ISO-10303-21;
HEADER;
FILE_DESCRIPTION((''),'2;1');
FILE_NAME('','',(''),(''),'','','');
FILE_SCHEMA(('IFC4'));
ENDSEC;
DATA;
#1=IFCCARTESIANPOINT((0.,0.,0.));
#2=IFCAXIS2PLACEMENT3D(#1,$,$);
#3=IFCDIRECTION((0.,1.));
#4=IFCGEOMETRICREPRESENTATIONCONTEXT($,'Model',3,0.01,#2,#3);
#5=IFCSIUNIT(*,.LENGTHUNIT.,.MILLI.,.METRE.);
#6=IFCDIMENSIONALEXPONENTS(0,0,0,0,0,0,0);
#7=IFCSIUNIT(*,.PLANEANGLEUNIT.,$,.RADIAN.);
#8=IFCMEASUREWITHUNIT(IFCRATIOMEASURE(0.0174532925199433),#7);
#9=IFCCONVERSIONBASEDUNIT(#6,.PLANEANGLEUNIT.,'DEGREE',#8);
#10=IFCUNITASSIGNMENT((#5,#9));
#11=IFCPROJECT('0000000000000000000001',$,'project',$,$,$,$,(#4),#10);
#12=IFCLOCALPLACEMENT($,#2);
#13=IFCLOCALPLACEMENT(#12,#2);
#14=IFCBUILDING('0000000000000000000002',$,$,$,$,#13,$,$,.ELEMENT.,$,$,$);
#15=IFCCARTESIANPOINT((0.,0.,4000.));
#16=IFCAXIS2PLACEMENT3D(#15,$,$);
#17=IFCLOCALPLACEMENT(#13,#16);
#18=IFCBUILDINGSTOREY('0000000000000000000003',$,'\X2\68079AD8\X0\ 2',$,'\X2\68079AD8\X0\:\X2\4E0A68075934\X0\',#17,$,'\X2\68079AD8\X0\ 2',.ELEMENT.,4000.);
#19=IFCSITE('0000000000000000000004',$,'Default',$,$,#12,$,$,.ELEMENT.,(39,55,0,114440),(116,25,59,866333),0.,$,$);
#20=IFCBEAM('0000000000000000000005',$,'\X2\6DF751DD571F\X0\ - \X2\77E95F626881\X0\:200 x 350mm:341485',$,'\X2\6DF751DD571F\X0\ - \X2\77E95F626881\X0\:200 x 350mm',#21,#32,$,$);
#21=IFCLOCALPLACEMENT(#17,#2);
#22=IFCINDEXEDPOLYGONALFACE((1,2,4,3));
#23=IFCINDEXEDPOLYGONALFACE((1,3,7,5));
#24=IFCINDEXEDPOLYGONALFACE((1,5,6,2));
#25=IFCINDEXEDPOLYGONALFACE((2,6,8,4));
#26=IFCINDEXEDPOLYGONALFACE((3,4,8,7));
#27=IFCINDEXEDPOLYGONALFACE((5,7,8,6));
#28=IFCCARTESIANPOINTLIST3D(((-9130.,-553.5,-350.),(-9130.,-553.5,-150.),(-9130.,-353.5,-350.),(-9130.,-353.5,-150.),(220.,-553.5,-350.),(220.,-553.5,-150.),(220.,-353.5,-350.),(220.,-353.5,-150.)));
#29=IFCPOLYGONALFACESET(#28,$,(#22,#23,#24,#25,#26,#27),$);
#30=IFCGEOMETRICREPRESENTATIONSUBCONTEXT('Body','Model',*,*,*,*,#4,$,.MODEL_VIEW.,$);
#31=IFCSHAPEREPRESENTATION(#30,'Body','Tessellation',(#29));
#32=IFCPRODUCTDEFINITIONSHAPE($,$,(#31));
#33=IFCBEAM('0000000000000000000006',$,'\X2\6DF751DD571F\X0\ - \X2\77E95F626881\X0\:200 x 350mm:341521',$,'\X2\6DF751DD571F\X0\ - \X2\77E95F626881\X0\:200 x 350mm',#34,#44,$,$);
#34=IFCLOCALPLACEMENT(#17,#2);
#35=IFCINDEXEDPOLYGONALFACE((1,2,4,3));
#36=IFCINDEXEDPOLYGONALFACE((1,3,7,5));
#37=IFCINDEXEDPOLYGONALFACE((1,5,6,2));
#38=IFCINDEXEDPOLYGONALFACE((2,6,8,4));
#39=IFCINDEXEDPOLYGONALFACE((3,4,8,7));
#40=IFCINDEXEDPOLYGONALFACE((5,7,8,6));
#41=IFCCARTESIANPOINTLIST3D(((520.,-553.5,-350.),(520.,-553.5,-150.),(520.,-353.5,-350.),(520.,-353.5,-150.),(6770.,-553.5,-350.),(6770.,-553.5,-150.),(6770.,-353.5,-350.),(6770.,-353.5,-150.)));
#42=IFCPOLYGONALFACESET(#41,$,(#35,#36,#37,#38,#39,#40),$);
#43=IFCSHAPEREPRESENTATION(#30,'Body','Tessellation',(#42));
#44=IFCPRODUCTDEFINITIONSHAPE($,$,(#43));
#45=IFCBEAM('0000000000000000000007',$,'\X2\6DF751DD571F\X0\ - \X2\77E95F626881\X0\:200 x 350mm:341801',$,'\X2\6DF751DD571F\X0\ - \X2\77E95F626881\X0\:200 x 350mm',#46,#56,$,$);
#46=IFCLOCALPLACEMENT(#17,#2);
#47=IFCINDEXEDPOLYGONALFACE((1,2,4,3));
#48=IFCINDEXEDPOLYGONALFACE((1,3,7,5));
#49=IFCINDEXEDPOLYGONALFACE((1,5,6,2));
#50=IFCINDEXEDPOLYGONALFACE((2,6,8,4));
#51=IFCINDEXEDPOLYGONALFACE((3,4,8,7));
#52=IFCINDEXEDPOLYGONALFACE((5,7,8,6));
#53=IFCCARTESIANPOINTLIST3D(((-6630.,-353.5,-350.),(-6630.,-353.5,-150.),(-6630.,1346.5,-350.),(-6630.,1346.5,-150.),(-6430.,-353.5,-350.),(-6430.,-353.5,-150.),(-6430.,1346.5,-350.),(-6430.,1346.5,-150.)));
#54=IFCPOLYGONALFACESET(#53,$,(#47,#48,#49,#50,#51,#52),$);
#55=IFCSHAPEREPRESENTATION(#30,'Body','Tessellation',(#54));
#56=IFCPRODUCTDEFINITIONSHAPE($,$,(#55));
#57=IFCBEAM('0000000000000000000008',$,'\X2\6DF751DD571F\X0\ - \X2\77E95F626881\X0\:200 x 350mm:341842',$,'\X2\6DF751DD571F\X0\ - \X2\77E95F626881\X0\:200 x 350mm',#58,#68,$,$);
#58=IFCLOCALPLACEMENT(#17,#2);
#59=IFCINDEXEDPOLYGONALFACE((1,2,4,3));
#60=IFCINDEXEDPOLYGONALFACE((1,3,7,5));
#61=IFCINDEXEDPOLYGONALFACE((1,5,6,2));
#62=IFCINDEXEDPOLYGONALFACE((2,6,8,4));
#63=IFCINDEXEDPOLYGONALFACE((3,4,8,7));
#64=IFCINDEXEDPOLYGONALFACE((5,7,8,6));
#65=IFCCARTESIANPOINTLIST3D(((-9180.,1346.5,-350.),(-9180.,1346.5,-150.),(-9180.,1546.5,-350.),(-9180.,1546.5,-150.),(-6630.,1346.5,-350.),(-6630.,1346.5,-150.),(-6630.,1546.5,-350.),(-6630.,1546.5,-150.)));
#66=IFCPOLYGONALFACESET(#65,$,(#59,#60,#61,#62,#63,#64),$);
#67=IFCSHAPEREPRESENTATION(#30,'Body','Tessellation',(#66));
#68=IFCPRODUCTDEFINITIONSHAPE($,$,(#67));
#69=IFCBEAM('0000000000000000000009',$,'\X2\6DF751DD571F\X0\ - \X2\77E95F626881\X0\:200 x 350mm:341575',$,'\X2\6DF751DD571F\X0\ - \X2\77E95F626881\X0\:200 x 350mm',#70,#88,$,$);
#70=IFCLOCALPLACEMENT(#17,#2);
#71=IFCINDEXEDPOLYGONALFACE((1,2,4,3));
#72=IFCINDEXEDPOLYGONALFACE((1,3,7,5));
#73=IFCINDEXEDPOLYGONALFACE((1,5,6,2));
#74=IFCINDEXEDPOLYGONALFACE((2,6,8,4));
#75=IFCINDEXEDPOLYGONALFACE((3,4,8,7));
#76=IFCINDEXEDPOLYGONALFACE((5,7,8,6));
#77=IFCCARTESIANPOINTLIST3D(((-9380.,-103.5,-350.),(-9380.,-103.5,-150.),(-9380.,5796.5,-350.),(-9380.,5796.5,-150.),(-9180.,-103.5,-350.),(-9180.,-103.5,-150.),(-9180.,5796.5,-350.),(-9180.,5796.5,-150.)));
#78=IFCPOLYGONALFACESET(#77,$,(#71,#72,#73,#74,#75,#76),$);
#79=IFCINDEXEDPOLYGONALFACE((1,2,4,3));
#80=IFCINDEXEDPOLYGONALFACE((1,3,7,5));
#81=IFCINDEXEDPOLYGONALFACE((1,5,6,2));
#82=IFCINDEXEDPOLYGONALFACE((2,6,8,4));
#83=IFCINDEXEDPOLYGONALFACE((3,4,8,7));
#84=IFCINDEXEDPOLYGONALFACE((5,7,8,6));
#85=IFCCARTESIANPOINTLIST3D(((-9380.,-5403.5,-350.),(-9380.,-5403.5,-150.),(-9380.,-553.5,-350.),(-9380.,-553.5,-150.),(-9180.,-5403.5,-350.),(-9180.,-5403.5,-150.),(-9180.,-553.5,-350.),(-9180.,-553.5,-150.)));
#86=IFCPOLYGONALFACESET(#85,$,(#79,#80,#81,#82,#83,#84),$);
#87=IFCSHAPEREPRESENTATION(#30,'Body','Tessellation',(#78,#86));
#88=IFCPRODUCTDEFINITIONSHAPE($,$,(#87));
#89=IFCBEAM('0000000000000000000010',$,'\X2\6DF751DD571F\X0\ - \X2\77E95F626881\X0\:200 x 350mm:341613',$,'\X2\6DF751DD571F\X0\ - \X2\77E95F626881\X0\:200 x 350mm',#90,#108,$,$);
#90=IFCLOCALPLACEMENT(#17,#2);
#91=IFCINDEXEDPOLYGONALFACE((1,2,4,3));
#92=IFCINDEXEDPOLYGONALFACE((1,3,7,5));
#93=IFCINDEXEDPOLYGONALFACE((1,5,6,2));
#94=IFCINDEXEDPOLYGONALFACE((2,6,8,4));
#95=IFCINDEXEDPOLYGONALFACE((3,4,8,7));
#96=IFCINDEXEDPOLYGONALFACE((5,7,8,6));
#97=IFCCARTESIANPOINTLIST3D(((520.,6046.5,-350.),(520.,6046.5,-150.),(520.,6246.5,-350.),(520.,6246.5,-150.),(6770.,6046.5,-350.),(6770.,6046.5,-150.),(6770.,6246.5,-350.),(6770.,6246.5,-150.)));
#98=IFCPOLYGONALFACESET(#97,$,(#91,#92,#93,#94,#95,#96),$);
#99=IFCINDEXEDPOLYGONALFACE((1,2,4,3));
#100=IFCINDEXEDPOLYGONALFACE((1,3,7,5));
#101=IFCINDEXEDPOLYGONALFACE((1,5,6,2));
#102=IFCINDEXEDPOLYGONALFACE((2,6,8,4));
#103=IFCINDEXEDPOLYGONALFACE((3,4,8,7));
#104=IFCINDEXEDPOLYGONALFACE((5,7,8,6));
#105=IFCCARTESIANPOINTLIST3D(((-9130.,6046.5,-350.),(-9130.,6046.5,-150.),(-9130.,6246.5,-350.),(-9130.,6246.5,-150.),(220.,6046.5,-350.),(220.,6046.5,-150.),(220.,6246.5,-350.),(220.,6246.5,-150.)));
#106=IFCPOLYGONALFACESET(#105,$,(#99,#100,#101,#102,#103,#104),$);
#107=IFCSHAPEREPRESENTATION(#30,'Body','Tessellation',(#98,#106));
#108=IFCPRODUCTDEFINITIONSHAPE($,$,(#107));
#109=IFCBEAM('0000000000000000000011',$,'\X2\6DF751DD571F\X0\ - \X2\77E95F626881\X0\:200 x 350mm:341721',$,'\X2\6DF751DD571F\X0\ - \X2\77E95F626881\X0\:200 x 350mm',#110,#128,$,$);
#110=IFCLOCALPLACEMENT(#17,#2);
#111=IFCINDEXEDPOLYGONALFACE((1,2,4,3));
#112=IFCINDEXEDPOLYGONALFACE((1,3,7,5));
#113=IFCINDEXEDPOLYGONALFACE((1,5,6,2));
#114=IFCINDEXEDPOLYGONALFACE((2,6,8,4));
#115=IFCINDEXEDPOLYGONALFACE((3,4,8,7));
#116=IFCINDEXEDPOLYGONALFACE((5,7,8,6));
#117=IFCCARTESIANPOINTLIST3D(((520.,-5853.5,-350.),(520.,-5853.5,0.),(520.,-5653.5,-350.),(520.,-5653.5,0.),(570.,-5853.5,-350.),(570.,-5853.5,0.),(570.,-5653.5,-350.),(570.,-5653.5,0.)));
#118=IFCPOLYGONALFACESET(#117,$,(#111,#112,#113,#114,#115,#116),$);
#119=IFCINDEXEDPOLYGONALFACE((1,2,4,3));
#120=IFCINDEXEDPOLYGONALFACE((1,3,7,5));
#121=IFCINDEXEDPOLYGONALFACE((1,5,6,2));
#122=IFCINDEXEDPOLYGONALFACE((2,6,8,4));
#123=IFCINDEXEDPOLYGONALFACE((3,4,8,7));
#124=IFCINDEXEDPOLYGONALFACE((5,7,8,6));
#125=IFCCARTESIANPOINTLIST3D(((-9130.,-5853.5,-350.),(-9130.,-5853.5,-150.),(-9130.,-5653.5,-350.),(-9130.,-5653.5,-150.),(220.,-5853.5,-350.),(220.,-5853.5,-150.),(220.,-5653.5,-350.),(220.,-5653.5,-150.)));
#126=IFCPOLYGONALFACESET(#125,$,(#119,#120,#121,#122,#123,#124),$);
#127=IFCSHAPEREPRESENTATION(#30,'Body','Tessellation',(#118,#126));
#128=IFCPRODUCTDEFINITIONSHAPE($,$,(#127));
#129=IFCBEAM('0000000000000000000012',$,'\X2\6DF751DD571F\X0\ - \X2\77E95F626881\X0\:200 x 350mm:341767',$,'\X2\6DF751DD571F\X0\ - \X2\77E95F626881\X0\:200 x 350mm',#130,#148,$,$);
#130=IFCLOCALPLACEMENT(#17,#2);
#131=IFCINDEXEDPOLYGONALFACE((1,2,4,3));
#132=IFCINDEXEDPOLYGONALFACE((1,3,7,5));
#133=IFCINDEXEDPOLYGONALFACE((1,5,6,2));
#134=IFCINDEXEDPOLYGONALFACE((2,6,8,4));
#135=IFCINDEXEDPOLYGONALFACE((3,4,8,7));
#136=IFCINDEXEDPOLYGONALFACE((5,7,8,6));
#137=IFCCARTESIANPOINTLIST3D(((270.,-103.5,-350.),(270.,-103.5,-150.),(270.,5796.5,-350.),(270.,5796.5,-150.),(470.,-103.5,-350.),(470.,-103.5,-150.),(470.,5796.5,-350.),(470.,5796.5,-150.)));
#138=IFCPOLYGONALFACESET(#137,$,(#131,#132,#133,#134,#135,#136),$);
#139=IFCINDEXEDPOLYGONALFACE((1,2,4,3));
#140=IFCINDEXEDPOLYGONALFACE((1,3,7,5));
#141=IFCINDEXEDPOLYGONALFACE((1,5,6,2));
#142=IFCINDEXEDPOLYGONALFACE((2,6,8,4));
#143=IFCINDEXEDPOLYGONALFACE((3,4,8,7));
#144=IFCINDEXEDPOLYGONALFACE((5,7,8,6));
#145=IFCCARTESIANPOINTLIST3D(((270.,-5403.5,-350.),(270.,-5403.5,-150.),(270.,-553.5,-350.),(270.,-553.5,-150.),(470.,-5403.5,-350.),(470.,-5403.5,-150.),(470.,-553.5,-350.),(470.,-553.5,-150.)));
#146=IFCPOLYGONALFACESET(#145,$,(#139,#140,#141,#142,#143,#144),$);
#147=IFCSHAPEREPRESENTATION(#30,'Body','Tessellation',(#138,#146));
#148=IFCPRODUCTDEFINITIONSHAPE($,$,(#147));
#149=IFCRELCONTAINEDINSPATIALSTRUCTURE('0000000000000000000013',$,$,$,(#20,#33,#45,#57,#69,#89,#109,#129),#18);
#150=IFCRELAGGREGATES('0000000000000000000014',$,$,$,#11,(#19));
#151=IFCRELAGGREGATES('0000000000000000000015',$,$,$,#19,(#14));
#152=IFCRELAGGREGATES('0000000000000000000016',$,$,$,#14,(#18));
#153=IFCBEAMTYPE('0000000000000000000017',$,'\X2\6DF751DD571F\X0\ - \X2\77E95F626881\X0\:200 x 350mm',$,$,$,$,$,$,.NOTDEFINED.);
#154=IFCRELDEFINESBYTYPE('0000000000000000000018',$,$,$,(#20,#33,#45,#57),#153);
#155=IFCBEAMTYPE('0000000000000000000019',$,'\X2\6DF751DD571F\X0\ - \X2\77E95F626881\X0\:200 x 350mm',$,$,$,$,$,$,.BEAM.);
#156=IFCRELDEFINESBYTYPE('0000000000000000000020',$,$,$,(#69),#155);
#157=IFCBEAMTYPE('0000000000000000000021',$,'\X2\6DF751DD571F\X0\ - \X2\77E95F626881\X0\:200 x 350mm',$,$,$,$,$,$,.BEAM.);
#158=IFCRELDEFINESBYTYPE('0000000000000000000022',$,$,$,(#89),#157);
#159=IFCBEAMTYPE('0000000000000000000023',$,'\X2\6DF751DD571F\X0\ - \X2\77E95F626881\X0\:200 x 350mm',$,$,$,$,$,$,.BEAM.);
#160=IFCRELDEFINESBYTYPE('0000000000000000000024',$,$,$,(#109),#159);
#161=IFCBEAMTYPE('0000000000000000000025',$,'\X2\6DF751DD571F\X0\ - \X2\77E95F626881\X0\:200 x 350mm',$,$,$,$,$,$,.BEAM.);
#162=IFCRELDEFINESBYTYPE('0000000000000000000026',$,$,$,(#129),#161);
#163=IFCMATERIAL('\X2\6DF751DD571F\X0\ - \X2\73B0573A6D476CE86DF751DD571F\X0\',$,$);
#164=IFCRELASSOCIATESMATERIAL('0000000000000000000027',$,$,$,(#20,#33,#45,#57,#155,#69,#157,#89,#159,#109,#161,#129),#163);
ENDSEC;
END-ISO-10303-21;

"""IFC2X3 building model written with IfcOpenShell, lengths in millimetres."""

from ifc_helpers import new_model, entity, si_unit, converted_unit, direction, frame, frame_2d, origin, place, context, subcontext, project, spatial, rectangle, extrude, source, transform, mapped, material, type_object, type_shapes, element, save


model = new_model("IFC2X3")

# Units and contexts
model_context = context("Model", 3, precision=0.01, world=origin(), true_north=direction((0.0, 1.0)))
body_context = subcontext(model_context, "Body", "Model", "MODEL_VIEW")
ifc_project = project(units=[si_unit("LENGTHUNIT", "METRE", prefix="MILLI"), converted_unit("PLANEANGLEUNIT", "DEGREE", entity("IfcRatioMeasure", 0.0174532925199433), si_unit("PLANEANGLEUNIT", "RADIAN"), dimensions=[0, 0, 0, 0, 0, 0, 0])], contexts=[model_context])

# Site, building, storey
site_placement = place(None, origin())
site = spatial("IfcSite", under=ifc_project, at=site_placement, Name="Default", CompositionType="ELEMENT", RefLatitude=(39, 55, 0, 114440), RefLongitude=(116, 25, 59, 866333), RefElevation=0.0)
building_placement = place(site_placement, origin())
building = spatial("IfcBuilding", under=site, at=building_placement, CompositionType="ELEMENT")
storey_placement = place(building_placement, frame((0.0, 0.0, 4000.0)))
storey = spatial("IfcBuildingStorey", under=building, at=storey_placement, Name="标高 2", ObjectType="标高:上标头", LongName="标高 2", CompositionType="ELEMENT", Elevation=4000.0)

# Beams
ifc_material_1 = material(Name="混凝土 - 现场浇注混凝土")
beam_type_1 = type_object("IfcBeamType", Name="混凝土 - 矩形梁:200 x 350mm", PredefinedType="NOTDEFINED")
beam_1_placement = place(storey_placement, frame((-9280.0, -453.5, 0.0)))
element("IfcBeam", 1, at=beam_1_placement, inside=storey, type_object=beam_type_1, material=ifc_material_1, Name="混凝土 - 矩形梁:200 x 350mm:341485", ObjectType="混凝土 - 矩形梁:200 x 350mm", context=body_context, shape_type="SweptSolid", body=[
    extrude(rectangle(XDim=200.0, YDim=200.0, at=frame_2d((0.0, 0.0), x_axis=(1.0, 0.0))), frame((150.0, 0.0, -250.0), z_axis=(1.0, 0.0, 0.0), x_axis=(0.0, 0.0, -1.0)), (0.0, 0.0, 1.0), 9350.0),
])
beam_2_placement = place(storey_placement, frame((370.0, -453.5, 0.0)))
element("IfcBeam", 2, at=beam_2_placement, inside=storey, type_object=beam_type_1, material=ifc_material_1, Name="混凝土 - 矩形梁:200 x 350mm:341521", ObjectType="混凝土 - 矩形梁:200 x 350mm", context=body_context, shape_type="SweptSolid", body=[
    extrude(rectangle(XDim=200.0, YDim=200.0, at=frame_2d((0.0, 0.0), x_axis=(1.0, 0.0))), frame((150.0, 0.0, -250.0), z_axis=(1.0, 0.0, 0.0), x_axis=(0.0, 0.0, -1.0)), (0.0, 0.0, 1.0), 6250.0),
])
beam_3_placement = place(storey_placement, frame((-6530.0, -453.5, 0.0), z_axis=(0.0, 0.0, 1.0), x_axis=(0.0, 1.0, 0.0)))
element("IfcBeam", 3, at=beam_3_placement, inside=storey, type_object=beam_type_1, material=ifc_material_1, Name="混凝土 - 矩形梁:200 x 350mm:341801", ObjectType="混凝土 - 矩形梁:200 x 350mm", context=body_context, shape_type="SweptSolid", body=[
    extrude(rectangle(XDim=200.0, YDim=200.0, at=frame_2d((0.0, 0.0), x_axis=(1.0, 0.0))), frame((100.0, 0.0, -250.0), z_axis=(1.0, 0.0, 0.0), x_axis=(0.0, 0.0, -1.0)), (0.0, 0.0, 1.0), 1700.0),
])
beam_4_placement = place(storey_placement, frame((-9280.0, 1446.5, 0.0)))
element("IfcBeam", 4, at=beam_4_placement, inside=storey, type_object=beam_type_1, material=ifc_material_1, Name="混凝土 - 矩形梁:200 x 350mm:341842", ObjectType="混凝土 - 矩形梁:200 x 350mm", context=body_context, shape_type="SweptSolid", body=[
    extrude(rectangle(XDim=200.0, YDim=200.0, at=frame_2d((0.0, 0.0), x_axis=(1.0, 0.0))), frame((100.0, 0.0, -250.0), z_axis=(1.0, 0.0, 0.0), x_axis=(0.0, 0.0, -1.0)), (0.0, 0.0, 1.0), 2550.0),
])
beam_type_2 = type_object("IfcBeamType", Name="混凝土 - 矩形梁:200 x 350mm", PredefinedType="BEAM", material=ifc_material_1)
shared_shape_1 = source(origin(), body_context, "Body", "SweptSolid", [
    extrude(rectangle(XDim=200.0, YDim=200.0, at=frame_2d((0.0, 0.0), x_axis=(0.0, 1.0))), frame((-9280.0, -103.5, 3750.0), z_axis=(0.0, 1.0, 0.0), x_axis=(-1.0, 0.0, 0.0)), (0.0, 0.0, 1.0), 5900.0),
    extrude(rectangle(XDim=200.0, YDim=200.0, at=frame_2d((0.0, 0.0), x_axis=(0.0, 1.0))), frame((-9280.0, -5403.5, 3750.0), z_axis=(0.0, 1.0, 0.0), x_axis=(-1.0, 0.0, 0.0)), (0.0, 0.0, 1.0), 4850.0),
])
type_shapes(beam_type_2, [shared_shape_1])
beam_5_placement = place(storey_placement, frame((0.0, 0.0, -4000.0)))
element("IfcBeam", 5, at=beam_5_placement, inside=storey, type_object=beam_type_2, material=ifc_material_1, Name="混凝土 - 矩形梁:200 x 350mm:341575", ObjectType="混凝土 - 矩形梁:200 x 350mm", context=body_context, shape_type="MappedRepresentation", body=[
    mapped(shared_shape_1, transform((0.0, 0.0, 0.0), scale=1.0)),
])
beam_type_3 = type_object("IfcBeamType", Name="混凝土 - 矩形梁:200 x 350mm", PredefinedType="BEAM", material=ifc_material_1)
shared_shape_2 = source(origin(), body_context, "Body", "SweptSolid", [
    extrude(rectangle(XDim=200.0, YDim=200.0, at=frame_2d((0.0, 0.0), x_axis=(1.0, 0.0))), frame((520.0, 6146.5, 3750.0), z_axis=(1.0, 0.0, 0.0), x_axis=(0.0, 0.0, -1.0)), (0.0, 0.0, 1.0), 6250.0),
    extrude(rectangle(XDim=200.0, YDim=200.0, at=frame_2d((0.0, 0.0), x_axis=(1.0, 0.0))), frame((-9130.0, 6146.5, 3750.0), z_axis=(1.0, 0.0, 0.0), x_axis=(0.0, 0.0, -1.0)), (0.0, 0.0, 1.0), 9350.0),
])
type_shapes(beam_type_3, [shared_shape_2])
beam_6_placement = place(storey_placement, frame((0.0, 0.0, -4000.0)))
element("IfcBeam", 6, at=beam_6_placement, inside=storey, type_object=beam_type_3, material=ifc_material_1, Name="混凝土 - 矩形梁:200 x 350mm:341613", ObjectType="混凝土 - 矩形梁:200 x 350mm", context=body_context, shape_type="MappedRepresentation", body=[
    mapped(shared_shape_2, transform((0.0, 0.0, 0.0), scale=1.0)),
])
beam_type_4 = type_object("IfcBeamType", Name="混凝土 - 矩形梁:200 x 350mm", PredefinedType="BEAM", material=ifc_material_1)
shared_shape_3 = source(origin(), body_context, "Body", "SweptSolid", [
    extrude(rectangle(XDim=350.0, YDim=200.0, at=frame_2d((0.0, 0.0), x_axis=(1.0, 0.0))), frame((520.0, -5753.5, 3825.0), z_axis=(1.0, 0.0, 0.0), x_axis=(0.0, 0.0, -1.0)), (0.0, 0.0, 1.0), 50.0),
    extrude(rectangle(XDim=200.0, YDim=200.0, at=frame_2d((0.0, 0.0), x_axis=(1.0, 0.0))), frame((-9130.0, -5753.5, 3750.0), z_axis=(1.0, 0.0, 0.0), x_axis=(0.0, 0.0, -1.0)), (0.0, 0.0, 1.0), 9350.0),
])
type_shapes(beam_type_4, [shared_shape_3])
beam_7_placement = place(storey_placement, frame((0.0, 0.0, -4000.0)))
element("IfcBeam", 7, at=beam_7_placement, inside=storey, type_object=beam_type_4, material=ifc_material_1, Name="混凝土 - 矩形梁:200 x 350mm:341721", ObjectType="混凝土 - 矩形梁:200 x 350mm", context=body_context, shape_type="MappedRepresentation", body=[
    mapped(shared_shape_3, transform((0.0, 0.0, 0.0), scale=1.0)),
])
beam_type_5 = type_object("IfcBeamType", Name="混凝土 - 矩形梁:200 x 350mm", PredefinedType="BEAM", material=ifc_material_1)
shared_shape_4 = source(origin(), body_context, "Body", "SweptSolid", [
    extrude(rectangle(XDim=200.0, YDim=200.0, at=frame_2d((0.0, 0.0), x_axis=(0.0, 1.0))), frame((370.0, -103.5, 3750.0), z_axis=(0.0, 1.0, 0.0), x_axis=(-1.0, 0.0, 0.0)), (0.0, 0.0, 1.0), 5900.0),
    extrude(rectangle(XDim=200.0, YDim=200.0, at=frame_2d((0.0, 0.0), x_axis=(0.0, 1.0))), frame((370.0, -5403.5, 3750.0), z_axis=(0.0, 1.0, 0.0), x_axis=(-1.0, 0.0, 0.0)), (0.0, 0.0, 1.0), 4850.0),
])
type_shapes(beam_type_5, [shared_shape_4])
beam_8_placement = place(storey_placement, frame((0.0, 0.0, -4000.0)))
element("IfcBeam", 8, at=beam_8_placement, inside=storey, type_object=beam_type_5, material=ifc_material_1, Name="混凝土 - 矩形梁:200 x 350mm:341767", ObjectType="混凝土 - 矩形梁:200 x 350mm", context=body_context, shape_type="MappedRepresentation", body=[
    mapped(shared_shape_4, transform((0.0, 0.0, 0.0), scale=1.0)),
])

save(model, "model.ifc")
